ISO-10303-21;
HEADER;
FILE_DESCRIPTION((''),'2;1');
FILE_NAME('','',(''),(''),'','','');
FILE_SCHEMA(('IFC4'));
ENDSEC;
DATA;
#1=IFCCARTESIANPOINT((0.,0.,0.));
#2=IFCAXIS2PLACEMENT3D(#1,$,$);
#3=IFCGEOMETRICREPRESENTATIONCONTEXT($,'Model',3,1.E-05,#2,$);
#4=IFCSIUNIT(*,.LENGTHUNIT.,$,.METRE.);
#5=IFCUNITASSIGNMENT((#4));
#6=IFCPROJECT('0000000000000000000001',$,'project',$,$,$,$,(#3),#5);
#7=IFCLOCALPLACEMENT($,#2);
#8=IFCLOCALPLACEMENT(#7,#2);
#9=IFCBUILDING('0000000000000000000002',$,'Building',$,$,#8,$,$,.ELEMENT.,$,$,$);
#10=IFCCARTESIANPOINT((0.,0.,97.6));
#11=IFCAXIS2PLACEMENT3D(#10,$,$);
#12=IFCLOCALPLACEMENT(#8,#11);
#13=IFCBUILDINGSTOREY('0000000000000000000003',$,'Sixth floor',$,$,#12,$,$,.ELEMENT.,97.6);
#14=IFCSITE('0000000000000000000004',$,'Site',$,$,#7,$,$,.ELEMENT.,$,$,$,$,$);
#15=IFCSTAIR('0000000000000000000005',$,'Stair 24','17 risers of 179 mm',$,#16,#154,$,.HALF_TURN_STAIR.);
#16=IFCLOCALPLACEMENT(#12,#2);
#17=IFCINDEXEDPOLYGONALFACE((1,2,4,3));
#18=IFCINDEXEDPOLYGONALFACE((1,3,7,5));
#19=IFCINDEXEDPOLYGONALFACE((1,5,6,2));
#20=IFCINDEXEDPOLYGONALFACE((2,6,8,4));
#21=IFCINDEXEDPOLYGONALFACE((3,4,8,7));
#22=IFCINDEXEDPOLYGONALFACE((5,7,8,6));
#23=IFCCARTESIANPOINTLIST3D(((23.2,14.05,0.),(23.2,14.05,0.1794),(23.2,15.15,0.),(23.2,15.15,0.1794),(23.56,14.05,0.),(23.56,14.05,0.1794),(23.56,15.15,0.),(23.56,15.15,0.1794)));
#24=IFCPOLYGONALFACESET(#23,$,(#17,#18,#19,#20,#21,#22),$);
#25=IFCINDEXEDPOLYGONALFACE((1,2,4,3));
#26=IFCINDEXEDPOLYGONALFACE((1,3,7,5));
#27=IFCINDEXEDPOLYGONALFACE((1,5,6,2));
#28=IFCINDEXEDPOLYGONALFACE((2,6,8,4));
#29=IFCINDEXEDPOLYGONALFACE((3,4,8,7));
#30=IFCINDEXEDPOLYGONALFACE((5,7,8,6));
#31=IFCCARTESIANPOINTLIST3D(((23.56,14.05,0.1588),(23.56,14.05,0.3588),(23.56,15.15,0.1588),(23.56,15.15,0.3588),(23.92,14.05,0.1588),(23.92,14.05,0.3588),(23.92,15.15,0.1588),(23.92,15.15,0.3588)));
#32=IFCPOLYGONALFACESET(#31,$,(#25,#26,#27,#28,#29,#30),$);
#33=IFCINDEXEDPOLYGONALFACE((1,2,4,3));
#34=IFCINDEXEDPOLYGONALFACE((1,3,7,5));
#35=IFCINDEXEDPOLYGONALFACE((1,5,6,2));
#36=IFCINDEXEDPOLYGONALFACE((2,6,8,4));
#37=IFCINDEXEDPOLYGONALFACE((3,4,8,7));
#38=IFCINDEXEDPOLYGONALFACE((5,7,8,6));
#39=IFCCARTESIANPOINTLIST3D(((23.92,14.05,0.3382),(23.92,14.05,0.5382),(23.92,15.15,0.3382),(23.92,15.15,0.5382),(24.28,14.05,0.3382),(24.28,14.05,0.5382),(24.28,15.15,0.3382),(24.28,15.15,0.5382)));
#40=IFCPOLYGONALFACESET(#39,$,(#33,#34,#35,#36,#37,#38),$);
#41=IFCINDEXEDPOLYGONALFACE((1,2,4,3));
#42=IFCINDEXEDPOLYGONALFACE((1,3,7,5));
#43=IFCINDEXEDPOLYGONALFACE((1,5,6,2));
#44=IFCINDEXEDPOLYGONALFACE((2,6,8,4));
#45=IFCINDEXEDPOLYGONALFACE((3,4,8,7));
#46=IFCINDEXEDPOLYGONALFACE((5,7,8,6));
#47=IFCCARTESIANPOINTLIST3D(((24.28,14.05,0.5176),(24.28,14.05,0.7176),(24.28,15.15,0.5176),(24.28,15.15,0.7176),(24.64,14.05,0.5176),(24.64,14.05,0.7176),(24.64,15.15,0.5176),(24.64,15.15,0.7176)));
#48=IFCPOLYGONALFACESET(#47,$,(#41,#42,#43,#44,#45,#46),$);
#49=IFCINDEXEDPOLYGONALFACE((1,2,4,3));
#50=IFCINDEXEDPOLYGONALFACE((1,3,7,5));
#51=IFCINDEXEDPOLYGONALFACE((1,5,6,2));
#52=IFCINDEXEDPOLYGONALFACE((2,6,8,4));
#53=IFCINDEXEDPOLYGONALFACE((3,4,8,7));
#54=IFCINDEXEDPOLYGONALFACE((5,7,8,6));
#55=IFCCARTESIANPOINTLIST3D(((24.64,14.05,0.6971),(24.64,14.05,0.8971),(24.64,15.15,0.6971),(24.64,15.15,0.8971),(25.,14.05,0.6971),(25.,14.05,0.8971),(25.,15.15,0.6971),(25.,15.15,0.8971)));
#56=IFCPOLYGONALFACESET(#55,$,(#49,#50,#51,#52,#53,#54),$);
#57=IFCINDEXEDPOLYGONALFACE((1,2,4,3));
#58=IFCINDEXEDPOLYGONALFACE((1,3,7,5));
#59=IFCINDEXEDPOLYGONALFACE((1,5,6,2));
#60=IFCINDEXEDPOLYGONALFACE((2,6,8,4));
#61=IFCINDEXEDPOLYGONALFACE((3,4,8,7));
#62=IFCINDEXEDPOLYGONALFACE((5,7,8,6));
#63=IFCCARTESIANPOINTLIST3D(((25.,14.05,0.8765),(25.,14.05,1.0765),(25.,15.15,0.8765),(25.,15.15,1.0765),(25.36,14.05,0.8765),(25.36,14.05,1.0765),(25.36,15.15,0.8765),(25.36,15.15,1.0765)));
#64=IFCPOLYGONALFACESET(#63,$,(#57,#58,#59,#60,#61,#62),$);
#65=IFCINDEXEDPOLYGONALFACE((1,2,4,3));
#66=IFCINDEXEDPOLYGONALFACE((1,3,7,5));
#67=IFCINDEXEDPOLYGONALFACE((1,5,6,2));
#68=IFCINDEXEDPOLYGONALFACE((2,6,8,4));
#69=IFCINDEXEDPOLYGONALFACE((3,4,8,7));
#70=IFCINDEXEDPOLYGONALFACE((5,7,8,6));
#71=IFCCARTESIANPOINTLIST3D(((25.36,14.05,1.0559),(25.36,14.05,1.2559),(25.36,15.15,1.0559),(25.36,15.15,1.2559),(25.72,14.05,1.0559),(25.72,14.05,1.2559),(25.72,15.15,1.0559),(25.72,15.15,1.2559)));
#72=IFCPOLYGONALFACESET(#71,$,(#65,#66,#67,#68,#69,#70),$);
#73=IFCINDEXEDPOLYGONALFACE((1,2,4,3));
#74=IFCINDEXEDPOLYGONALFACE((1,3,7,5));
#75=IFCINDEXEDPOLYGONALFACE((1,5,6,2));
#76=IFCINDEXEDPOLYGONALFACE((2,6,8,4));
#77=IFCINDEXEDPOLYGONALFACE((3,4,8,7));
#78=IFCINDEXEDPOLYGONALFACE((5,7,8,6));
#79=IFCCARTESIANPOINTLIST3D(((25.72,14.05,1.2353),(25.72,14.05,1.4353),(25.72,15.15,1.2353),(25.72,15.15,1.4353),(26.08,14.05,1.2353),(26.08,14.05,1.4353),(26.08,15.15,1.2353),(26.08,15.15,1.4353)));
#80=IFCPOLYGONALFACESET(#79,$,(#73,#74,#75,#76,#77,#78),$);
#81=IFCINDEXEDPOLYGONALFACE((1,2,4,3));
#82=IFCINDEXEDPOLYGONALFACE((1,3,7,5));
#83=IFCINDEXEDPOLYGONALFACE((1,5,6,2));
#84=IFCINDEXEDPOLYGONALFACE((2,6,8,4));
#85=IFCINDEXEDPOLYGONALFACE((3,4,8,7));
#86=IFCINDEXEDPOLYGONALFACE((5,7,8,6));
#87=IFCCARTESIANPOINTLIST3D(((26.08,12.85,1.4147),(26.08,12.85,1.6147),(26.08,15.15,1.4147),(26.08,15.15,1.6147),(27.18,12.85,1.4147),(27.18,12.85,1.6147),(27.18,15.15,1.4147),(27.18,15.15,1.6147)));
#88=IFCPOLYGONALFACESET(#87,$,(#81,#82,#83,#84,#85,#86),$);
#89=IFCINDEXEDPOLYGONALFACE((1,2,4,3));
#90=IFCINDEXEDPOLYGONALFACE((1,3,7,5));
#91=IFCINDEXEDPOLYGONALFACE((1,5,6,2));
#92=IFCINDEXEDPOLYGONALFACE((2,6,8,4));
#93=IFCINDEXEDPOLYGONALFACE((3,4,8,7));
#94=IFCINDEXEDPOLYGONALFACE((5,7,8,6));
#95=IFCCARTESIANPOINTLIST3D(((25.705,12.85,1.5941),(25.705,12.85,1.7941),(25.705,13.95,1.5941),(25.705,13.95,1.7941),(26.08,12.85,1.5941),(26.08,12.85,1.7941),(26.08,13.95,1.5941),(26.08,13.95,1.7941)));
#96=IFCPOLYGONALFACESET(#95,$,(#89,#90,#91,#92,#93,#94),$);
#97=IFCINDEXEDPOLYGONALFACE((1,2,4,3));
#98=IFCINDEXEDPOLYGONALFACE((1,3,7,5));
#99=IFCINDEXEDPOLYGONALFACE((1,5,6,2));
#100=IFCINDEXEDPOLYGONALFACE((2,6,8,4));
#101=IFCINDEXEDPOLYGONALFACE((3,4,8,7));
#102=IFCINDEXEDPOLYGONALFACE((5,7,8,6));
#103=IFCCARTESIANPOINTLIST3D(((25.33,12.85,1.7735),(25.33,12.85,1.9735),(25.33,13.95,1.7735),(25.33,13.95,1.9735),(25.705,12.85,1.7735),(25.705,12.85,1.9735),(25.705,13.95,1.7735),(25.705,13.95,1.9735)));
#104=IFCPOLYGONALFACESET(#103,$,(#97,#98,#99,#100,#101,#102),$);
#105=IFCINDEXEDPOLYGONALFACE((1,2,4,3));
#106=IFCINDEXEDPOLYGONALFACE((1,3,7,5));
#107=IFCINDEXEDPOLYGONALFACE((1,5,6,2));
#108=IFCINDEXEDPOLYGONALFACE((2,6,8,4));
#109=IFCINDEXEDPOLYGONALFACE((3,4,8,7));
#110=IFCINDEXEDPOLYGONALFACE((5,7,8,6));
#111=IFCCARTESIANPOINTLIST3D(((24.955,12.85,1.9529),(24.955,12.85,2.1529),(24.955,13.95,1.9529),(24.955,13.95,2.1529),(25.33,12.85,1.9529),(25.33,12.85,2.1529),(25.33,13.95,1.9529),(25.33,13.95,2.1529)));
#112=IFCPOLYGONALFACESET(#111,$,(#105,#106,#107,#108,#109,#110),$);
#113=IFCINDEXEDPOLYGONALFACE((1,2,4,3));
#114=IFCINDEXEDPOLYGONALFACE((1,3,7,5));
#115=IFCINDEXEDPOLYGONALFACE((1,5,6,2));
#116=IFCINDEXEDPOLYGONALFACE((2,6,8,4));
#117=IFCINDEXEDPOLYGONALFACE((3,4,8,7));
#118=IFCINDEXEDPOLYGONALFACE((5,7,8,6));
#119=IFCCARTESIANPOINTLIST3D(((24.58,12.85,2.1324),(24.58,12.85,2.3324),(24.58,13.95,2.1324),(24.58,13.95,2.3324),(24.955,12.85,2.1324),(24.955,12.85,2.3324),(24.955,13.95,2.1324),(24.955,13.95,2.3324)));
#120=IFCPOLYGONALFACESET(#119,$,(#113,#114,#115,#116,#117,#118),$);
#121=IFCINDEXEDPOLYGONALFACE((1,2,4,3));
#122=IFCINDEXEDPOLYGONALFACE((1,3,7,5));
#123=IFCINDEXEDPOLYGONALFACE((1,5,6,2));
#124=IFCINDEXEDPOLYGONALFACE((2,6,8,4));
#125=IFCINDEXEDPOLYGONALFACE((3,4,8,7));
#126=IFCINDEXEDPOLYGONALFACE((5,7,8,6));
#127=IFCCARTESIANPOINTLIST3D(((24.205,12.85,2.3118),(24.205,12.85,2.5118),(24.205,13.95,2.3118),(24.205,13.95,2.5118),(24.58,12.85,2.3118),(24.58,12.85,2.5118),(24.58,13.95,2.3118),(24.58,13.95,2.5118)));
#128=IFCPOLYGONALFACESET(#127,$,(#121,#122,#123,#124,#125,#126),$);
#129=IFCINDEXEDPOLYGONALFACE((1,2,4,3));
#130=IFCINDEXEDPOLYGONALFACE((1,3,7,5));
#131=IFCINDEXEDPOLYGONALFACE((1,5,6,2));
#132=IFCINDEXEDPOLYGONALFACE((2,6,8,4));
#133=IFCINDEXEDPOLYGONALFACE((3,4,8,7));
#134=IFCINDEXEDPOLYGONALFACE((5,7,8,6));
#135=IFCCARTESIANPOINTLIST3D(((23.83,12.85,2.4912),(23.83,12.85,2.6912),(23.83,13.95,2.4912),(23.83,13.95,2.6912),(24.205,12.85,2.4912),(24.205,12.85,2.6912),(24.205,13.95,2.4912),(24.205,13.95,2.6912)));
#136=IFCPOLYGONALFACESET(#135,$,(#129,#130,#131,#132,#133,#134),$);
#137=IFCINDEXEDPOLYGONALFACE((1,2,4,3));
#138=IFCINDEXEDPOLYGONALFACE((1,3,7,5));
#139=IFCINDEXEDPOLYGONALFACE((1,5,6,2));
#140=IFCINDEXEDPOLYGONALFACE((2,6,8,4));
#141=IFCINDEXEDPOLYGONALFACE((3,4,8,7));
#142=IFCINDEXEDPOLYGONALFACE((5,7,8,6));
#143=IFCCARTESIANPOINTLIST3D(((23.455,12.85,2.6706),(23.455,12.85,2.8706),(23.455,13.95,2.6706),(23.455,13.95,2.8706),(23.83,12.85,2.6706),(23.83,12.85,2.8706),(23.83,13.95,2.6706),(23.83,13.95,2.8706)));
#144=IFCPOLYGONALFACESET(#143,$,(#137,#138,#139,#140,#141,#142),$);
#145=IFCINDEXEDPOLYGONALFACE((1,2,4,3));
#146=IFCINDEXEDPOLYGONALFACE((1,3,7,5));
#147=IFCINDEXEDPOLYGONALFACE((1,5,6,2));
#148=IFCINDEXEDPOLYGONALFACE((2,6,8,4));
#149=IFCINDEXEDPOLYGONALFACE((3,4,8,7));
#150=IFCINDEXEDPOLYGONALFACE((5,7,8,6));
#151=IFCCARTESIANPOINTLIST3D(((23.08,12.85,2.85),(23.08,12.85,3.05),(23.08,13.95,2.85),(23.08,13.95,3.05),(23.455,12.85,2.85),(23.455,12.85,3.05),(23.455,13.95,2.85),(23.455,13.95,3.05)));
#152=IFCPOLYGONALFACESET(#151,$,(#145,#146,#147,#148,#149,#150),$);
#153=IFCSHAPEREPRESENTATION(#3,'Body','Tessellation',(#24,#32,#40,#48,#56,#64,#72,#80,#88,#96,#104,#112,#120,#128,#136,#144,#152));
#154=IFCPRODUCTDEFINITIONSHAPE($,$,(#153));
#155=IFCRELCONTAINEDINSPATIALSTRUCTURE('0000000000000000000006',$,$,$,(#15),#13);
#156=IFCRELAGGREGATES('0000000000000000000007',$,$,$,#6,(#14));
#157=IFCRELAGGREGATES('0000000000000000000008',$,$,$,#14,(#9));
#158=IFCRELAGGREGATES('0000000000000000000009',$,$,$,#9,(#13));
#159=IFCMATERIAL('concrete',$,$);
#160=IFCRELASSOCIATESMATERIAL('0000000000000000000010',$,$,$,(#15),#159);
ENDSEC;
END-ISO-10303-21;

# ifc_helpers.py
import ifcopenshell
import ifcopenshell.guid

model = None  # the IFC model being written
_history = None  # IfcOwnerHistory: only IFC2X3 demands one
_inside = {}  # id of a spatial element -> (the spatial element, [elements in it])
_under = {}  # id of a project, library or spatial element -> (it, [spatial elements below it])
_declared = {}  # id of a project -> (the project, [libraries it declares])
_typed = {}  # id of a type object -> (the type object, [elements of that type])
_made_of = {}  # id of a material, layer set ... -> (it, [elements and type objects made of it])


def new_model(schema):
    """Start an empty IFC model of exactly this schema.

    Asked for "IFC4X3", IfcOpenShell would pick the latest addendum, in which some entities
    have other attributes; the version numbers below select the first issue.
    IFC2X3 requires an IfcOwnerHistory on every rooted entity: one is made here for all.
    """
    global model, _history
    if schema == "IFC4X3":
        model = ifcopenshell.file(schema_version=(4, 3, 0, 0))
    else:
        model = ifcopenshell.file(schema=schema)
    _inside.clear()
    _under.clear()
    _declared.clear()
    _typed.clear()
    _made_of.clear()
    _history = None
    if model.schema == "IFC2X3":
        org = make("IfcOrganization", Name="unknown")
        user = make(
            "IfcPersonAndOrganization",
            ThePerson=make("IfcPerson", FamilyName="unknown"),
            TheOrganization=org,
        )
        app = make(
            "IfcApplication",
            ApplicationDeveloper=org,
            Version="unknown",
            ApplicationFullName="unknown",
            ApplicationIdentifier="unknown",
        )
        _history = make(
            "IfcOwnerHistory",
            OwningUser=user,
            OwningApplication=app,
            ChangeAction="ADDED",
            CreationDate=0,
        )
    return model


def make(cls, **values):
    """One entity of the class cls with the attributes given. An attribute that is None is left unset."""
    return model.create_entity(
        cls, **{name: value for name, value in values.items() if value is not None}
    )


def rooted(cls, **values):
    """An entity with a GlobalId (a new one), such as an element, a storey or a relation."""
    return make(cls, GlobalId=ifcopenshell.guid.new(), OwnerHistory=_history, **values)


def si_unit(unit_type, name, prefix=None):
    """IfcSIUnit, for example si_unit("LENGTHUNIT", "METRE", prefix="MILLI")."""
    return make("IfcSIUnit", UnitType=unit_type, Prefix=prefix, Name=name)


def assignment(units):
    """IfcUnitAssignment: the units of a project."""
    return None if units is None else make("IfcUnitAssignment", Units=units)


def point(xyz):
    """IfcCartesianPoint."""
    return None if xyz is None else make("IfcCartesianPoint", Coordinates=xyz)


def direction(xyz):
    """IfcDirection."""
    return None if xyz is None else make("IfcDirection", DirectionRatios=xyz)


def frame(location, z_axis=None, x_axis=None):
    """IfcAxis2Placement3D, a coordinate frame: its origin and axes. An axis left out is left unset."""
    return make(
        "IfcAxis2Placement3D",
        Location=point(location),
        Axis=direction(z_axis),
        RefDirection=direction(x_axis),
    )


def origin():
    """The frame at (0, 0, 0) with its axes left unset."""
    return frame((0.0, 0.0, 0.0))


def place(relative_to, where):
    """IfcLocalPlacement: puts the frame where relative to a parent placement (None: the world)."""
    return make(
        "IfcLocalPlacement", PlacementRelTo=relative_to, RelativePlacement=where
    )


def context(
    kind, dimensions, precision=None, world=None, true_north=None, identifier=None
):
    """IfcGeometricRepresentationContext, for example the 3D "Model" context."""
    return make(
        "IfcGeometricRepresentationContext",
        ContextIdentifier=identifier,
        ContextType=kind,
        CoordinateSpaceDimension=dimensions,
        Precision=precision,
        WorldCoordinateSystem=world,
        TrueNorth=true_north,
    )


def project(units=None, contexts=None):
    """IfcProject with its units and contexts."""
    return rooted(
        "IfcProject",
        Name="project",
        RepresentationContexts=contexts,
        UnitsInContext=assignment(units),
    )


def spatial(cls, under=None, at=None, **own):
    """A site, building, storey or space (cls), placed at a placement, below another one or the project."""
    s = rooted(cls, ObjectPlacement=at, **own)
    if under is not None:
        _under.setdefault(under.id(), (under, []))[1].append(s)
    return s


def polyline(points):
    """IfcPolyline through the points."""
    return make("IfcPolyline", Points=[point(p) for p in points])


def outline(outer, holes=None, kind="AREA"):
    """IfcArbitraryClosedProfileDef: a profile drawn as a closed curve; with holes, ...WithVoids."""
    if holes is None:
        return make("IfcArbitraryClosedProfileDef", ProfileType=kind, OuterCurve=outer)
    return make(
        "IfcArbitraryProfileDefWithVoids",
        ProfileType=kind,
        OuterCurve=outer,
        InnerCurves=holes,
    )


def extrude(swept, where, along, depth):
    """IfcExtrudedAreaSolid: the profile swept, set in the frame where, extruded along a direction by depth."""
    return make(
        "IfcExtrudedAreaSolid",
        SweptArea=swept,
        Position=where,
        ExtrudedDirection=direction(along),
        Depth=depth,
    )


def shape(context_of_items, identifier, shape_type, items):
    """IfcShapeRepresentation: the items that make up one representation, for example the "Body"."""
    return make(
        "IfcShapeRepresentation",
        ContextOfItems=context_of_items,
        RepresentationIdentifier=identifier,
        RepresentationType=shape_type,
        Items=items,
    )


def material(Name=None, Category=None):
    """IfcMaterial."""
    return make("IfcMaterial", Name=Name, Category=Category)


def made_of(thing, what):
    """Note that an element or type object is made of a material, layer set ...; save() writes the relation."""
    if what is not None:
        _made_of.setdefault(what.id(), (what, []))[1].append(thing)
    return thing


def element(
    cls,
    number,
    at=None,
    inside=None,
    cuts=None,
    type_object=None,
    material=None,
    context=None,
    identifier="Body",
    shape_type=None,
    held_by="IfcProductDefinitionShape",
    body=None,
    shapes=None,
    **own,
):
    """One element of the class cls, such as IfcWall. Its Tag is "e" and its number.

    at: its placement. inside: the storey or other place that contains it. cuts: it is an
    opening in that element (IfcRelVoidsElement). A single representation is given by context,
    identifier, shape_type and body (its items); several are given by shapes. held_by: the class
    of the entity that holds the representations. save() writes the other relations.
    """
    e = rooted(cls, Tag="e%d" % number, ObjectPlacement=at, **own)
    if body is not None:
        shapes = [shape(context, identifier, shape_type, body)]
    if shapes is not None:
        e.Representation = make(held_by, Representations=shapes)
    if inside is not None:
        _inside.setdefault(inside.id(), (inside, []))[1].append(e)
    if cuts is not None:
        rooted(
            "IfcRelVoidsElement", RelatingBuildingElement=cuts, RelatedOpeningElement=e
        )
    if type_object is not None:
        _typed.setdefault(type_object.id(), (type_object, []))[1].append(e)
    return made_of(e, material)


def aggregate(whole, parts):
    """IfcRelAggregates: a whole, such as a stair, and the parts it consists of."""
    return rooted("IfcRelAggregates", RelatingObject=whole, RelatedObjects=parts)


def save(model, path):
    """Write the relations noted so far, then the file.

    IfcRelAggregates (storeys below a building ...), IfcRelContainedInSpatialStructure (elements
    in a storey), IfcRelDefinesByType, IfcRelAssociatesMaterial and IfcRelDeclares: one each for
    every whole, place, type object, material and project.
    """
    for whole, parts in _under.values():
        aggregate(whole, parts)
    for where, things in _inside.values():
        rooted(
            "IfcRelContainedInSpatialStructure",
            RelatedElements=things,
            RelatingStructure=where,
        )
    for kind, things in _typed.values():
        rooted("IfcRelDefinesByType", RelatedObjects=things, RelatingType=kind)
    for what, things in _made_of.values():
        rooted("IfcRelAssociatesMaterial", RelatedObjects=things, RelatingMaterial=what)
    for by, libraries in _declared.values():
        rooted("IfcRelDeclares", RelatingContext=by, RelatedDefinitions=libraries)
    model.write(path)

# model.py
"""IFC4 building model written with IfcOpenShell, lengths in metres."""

from ifc_helpers import new_model, si_unit, frame, origin, place, context, project, spatial, polyline, outline, extrude, material, element, save


model = new_model("IFC4")

# Units and contexts
model_context = context("Model", 3, precision=1e-05, world=origin())
ifc_project = project(units=[si_unit("LENGTHUNIT", "METRE")], contexts=[model_context])

# Site, building, storey
site_placement = place(None, origin())
site = spatial("IfcSite", under=ifc_project, at=site_placement, Name="Site", CompositionType="ELEMENT")
building_placement = place(site_placement, origin())
building = spatial("IfcBuilding", under=site, at=building_placement, Name="Building", CompositionType="ELEMENT")
storey_placement = place(building_placement, frame((0.0, 0.0, 97.6)))
storey = spatial("IfcBuildingStorey", under=building, at=storey_placement, Name="Sixth floor", CompositionType="ELEMENT", Elevation=97.6)

# Shared definitions
ifc_material = material(Name="concrete")

# Stair
stair_placement = place(storey_placement, frame((23.2, 14.6, 0.0), z_axis=(0.0, 0.0, 1.0), x_axis=(1.0, 0.0, 0.0)))
element("IfcStair", 1, at=stair_placement, inside=storey, material=ifc_material, Name="Stair 24", Description="17 risers of 179 mm", PredefinedType="HALF_TURN_STAIR", context=model_context, shape_type="SweptSolid", body=[
    extrude(outline(polyline([(0.0, -0.55), (0.36, -0.55), (0.36, 0.55), (0.0, 0.55), (0.0, -0.55)])), origin(), (0.0, 0.0, 1.0), 0.1794),
    extrude(outline(polyline([(0.36, -0.55), (0.72, -0.55), (0.72, 0.55), (0.36, 0.55), (0.36, -0.55)])), frame((0.0, 0.0, 0.1588)), (0.0, 0.0, 1.0), 0.2),
    extrude(outline(polyline([(0.72, -0.55), (1.08, -0.55), (1.08, 0.55), (0.72, 0.55), (0.72, -0.55)])), frame((0.0, 0.0, 0.3382)), (0.0, 0.0, 1.0), 0.2),
    extrude(outline(polyline([(1.08, -0.55), (1.44, -0.55), (1.44, 0.55), (1.08, 0.55), (1.08, -0.55)])), frame((0.0, 0.0, 0.5176)), (0.0, 0.0, 1.0), 0.2),
    extrude(outline(polyline([(1.44, -0.55), (1.8, -0.55), (1.8, 0.55), (1.44, 0.55), (1.44, -0.55)])), frame((0.0, 0.0, 0.6971)), (0.0, 0.0, 1.0), 0.2),
    extrude(outline(polyline([(1.8, -0.55), (2.16, -0.55), (2.16, 0.55), (1.8, 0.55), (1.8, -0.55)])), frame((0.0, 0.0, 0.8765)), (0.0, 0.0, 1.0), 0.2),
    extrude(outline(polyline([(2.16, -0.55), (2.52, -0.55), (2.52, 0.55), (2.16, 0.55), (2.16, -0.55)])), frame((0.0, 0.0, 1.0559)), (0.0, 0.0, 1.0), 0.2),
    extrude(outline(polyline([(2.52, -0.55), (2.88, -0.55), (2.88, 0.55), (2.52, 0.55), (2.52, -0.55)])), frame((0.0, 0.0, 1.2353)), (0.0, 0.0, 1.0), 0.2),
    extrude(outline(polyline([(2.88, -1.75), (3.98, -1.75), (3.98, 0.55), (2.88, 0.55), (2.88, -1.75)])), frame((0.0, 0.0, 1.4147)), (0.0, 0.0, 1.0), 0.2),
    extrude(outline(polyline([(2.505, -1.75), (2.88, -1.75), (2.88, -0.65), (2.505, -0.65), (2.505, -1.75)])), frame((0.0, 0.0, 1.5941)), (0.0, 0.0, 1.0), 0.2),
    extrude(outline(polyline([(2.13, -1.75), (2.505, -1.75), (2.505, -0.65), (2.13, -0.65), (2.13, -1.75)])), frame((0.0, 0.0, 1.7735)), (0.0, 0.0, 1.0), 0.2),
    extrude(outline(polyline([(1.755, -1.75), (2.13, -1.75), (2.13, -0.65), (1.755, -0.65), (1.755, -1.75)])), frame((0.0, 0.0, 1.9529)), (0.0, 0.0, 1.0), 0.2),
    extrude(outline(polyline([(1.38, -1.75), (1.755, -1.75), (1.755, -0.65), (1.38, -0.65), (1.38, -1.75)])), frame((0.0, 0.0, 2.1324)), (0.0, 0.0, 1.0), 0.2),
    extrude(outline(polyline([(1.005, -1.75), (1.38, -1.75), (1.38, -0.65), (1.005, -0.65), (1.005, -1.75)])), frame((0.0, 0.0, 2.3118)), (0.0, 0.0, 1.0), 0.2),
    extrude(outline(polyline([(0.63, -1.75), (1.005, -1.75), (1.005, -0.65), (0.63, -0.65), (0.63, -1.75)])), frame((0.0, 0.0, 2.4912)), (0.0, 0.0, 1.0), 0.2),
    extrude(outline(polyline([(0.255, -1.75), (0.63, -1.75), (0.63, -0.65), (0.255, -0.65), (0.255, -1.75)])), frame((0.0, 0.0, 2.6706)), (0.0, 0.0, 1.0), 0.2),
    extrude(outline(polyline([(-0.12, -1.75), (0.255, -1.75), (0.255, -0.65), (-0.12, -0.65), (-0.12, -1.75)])), frame((0.0, 0.0, 2.85)), (0.0, 0.0, 1.0), 0.2),
])

save(model, "model.ifc")
